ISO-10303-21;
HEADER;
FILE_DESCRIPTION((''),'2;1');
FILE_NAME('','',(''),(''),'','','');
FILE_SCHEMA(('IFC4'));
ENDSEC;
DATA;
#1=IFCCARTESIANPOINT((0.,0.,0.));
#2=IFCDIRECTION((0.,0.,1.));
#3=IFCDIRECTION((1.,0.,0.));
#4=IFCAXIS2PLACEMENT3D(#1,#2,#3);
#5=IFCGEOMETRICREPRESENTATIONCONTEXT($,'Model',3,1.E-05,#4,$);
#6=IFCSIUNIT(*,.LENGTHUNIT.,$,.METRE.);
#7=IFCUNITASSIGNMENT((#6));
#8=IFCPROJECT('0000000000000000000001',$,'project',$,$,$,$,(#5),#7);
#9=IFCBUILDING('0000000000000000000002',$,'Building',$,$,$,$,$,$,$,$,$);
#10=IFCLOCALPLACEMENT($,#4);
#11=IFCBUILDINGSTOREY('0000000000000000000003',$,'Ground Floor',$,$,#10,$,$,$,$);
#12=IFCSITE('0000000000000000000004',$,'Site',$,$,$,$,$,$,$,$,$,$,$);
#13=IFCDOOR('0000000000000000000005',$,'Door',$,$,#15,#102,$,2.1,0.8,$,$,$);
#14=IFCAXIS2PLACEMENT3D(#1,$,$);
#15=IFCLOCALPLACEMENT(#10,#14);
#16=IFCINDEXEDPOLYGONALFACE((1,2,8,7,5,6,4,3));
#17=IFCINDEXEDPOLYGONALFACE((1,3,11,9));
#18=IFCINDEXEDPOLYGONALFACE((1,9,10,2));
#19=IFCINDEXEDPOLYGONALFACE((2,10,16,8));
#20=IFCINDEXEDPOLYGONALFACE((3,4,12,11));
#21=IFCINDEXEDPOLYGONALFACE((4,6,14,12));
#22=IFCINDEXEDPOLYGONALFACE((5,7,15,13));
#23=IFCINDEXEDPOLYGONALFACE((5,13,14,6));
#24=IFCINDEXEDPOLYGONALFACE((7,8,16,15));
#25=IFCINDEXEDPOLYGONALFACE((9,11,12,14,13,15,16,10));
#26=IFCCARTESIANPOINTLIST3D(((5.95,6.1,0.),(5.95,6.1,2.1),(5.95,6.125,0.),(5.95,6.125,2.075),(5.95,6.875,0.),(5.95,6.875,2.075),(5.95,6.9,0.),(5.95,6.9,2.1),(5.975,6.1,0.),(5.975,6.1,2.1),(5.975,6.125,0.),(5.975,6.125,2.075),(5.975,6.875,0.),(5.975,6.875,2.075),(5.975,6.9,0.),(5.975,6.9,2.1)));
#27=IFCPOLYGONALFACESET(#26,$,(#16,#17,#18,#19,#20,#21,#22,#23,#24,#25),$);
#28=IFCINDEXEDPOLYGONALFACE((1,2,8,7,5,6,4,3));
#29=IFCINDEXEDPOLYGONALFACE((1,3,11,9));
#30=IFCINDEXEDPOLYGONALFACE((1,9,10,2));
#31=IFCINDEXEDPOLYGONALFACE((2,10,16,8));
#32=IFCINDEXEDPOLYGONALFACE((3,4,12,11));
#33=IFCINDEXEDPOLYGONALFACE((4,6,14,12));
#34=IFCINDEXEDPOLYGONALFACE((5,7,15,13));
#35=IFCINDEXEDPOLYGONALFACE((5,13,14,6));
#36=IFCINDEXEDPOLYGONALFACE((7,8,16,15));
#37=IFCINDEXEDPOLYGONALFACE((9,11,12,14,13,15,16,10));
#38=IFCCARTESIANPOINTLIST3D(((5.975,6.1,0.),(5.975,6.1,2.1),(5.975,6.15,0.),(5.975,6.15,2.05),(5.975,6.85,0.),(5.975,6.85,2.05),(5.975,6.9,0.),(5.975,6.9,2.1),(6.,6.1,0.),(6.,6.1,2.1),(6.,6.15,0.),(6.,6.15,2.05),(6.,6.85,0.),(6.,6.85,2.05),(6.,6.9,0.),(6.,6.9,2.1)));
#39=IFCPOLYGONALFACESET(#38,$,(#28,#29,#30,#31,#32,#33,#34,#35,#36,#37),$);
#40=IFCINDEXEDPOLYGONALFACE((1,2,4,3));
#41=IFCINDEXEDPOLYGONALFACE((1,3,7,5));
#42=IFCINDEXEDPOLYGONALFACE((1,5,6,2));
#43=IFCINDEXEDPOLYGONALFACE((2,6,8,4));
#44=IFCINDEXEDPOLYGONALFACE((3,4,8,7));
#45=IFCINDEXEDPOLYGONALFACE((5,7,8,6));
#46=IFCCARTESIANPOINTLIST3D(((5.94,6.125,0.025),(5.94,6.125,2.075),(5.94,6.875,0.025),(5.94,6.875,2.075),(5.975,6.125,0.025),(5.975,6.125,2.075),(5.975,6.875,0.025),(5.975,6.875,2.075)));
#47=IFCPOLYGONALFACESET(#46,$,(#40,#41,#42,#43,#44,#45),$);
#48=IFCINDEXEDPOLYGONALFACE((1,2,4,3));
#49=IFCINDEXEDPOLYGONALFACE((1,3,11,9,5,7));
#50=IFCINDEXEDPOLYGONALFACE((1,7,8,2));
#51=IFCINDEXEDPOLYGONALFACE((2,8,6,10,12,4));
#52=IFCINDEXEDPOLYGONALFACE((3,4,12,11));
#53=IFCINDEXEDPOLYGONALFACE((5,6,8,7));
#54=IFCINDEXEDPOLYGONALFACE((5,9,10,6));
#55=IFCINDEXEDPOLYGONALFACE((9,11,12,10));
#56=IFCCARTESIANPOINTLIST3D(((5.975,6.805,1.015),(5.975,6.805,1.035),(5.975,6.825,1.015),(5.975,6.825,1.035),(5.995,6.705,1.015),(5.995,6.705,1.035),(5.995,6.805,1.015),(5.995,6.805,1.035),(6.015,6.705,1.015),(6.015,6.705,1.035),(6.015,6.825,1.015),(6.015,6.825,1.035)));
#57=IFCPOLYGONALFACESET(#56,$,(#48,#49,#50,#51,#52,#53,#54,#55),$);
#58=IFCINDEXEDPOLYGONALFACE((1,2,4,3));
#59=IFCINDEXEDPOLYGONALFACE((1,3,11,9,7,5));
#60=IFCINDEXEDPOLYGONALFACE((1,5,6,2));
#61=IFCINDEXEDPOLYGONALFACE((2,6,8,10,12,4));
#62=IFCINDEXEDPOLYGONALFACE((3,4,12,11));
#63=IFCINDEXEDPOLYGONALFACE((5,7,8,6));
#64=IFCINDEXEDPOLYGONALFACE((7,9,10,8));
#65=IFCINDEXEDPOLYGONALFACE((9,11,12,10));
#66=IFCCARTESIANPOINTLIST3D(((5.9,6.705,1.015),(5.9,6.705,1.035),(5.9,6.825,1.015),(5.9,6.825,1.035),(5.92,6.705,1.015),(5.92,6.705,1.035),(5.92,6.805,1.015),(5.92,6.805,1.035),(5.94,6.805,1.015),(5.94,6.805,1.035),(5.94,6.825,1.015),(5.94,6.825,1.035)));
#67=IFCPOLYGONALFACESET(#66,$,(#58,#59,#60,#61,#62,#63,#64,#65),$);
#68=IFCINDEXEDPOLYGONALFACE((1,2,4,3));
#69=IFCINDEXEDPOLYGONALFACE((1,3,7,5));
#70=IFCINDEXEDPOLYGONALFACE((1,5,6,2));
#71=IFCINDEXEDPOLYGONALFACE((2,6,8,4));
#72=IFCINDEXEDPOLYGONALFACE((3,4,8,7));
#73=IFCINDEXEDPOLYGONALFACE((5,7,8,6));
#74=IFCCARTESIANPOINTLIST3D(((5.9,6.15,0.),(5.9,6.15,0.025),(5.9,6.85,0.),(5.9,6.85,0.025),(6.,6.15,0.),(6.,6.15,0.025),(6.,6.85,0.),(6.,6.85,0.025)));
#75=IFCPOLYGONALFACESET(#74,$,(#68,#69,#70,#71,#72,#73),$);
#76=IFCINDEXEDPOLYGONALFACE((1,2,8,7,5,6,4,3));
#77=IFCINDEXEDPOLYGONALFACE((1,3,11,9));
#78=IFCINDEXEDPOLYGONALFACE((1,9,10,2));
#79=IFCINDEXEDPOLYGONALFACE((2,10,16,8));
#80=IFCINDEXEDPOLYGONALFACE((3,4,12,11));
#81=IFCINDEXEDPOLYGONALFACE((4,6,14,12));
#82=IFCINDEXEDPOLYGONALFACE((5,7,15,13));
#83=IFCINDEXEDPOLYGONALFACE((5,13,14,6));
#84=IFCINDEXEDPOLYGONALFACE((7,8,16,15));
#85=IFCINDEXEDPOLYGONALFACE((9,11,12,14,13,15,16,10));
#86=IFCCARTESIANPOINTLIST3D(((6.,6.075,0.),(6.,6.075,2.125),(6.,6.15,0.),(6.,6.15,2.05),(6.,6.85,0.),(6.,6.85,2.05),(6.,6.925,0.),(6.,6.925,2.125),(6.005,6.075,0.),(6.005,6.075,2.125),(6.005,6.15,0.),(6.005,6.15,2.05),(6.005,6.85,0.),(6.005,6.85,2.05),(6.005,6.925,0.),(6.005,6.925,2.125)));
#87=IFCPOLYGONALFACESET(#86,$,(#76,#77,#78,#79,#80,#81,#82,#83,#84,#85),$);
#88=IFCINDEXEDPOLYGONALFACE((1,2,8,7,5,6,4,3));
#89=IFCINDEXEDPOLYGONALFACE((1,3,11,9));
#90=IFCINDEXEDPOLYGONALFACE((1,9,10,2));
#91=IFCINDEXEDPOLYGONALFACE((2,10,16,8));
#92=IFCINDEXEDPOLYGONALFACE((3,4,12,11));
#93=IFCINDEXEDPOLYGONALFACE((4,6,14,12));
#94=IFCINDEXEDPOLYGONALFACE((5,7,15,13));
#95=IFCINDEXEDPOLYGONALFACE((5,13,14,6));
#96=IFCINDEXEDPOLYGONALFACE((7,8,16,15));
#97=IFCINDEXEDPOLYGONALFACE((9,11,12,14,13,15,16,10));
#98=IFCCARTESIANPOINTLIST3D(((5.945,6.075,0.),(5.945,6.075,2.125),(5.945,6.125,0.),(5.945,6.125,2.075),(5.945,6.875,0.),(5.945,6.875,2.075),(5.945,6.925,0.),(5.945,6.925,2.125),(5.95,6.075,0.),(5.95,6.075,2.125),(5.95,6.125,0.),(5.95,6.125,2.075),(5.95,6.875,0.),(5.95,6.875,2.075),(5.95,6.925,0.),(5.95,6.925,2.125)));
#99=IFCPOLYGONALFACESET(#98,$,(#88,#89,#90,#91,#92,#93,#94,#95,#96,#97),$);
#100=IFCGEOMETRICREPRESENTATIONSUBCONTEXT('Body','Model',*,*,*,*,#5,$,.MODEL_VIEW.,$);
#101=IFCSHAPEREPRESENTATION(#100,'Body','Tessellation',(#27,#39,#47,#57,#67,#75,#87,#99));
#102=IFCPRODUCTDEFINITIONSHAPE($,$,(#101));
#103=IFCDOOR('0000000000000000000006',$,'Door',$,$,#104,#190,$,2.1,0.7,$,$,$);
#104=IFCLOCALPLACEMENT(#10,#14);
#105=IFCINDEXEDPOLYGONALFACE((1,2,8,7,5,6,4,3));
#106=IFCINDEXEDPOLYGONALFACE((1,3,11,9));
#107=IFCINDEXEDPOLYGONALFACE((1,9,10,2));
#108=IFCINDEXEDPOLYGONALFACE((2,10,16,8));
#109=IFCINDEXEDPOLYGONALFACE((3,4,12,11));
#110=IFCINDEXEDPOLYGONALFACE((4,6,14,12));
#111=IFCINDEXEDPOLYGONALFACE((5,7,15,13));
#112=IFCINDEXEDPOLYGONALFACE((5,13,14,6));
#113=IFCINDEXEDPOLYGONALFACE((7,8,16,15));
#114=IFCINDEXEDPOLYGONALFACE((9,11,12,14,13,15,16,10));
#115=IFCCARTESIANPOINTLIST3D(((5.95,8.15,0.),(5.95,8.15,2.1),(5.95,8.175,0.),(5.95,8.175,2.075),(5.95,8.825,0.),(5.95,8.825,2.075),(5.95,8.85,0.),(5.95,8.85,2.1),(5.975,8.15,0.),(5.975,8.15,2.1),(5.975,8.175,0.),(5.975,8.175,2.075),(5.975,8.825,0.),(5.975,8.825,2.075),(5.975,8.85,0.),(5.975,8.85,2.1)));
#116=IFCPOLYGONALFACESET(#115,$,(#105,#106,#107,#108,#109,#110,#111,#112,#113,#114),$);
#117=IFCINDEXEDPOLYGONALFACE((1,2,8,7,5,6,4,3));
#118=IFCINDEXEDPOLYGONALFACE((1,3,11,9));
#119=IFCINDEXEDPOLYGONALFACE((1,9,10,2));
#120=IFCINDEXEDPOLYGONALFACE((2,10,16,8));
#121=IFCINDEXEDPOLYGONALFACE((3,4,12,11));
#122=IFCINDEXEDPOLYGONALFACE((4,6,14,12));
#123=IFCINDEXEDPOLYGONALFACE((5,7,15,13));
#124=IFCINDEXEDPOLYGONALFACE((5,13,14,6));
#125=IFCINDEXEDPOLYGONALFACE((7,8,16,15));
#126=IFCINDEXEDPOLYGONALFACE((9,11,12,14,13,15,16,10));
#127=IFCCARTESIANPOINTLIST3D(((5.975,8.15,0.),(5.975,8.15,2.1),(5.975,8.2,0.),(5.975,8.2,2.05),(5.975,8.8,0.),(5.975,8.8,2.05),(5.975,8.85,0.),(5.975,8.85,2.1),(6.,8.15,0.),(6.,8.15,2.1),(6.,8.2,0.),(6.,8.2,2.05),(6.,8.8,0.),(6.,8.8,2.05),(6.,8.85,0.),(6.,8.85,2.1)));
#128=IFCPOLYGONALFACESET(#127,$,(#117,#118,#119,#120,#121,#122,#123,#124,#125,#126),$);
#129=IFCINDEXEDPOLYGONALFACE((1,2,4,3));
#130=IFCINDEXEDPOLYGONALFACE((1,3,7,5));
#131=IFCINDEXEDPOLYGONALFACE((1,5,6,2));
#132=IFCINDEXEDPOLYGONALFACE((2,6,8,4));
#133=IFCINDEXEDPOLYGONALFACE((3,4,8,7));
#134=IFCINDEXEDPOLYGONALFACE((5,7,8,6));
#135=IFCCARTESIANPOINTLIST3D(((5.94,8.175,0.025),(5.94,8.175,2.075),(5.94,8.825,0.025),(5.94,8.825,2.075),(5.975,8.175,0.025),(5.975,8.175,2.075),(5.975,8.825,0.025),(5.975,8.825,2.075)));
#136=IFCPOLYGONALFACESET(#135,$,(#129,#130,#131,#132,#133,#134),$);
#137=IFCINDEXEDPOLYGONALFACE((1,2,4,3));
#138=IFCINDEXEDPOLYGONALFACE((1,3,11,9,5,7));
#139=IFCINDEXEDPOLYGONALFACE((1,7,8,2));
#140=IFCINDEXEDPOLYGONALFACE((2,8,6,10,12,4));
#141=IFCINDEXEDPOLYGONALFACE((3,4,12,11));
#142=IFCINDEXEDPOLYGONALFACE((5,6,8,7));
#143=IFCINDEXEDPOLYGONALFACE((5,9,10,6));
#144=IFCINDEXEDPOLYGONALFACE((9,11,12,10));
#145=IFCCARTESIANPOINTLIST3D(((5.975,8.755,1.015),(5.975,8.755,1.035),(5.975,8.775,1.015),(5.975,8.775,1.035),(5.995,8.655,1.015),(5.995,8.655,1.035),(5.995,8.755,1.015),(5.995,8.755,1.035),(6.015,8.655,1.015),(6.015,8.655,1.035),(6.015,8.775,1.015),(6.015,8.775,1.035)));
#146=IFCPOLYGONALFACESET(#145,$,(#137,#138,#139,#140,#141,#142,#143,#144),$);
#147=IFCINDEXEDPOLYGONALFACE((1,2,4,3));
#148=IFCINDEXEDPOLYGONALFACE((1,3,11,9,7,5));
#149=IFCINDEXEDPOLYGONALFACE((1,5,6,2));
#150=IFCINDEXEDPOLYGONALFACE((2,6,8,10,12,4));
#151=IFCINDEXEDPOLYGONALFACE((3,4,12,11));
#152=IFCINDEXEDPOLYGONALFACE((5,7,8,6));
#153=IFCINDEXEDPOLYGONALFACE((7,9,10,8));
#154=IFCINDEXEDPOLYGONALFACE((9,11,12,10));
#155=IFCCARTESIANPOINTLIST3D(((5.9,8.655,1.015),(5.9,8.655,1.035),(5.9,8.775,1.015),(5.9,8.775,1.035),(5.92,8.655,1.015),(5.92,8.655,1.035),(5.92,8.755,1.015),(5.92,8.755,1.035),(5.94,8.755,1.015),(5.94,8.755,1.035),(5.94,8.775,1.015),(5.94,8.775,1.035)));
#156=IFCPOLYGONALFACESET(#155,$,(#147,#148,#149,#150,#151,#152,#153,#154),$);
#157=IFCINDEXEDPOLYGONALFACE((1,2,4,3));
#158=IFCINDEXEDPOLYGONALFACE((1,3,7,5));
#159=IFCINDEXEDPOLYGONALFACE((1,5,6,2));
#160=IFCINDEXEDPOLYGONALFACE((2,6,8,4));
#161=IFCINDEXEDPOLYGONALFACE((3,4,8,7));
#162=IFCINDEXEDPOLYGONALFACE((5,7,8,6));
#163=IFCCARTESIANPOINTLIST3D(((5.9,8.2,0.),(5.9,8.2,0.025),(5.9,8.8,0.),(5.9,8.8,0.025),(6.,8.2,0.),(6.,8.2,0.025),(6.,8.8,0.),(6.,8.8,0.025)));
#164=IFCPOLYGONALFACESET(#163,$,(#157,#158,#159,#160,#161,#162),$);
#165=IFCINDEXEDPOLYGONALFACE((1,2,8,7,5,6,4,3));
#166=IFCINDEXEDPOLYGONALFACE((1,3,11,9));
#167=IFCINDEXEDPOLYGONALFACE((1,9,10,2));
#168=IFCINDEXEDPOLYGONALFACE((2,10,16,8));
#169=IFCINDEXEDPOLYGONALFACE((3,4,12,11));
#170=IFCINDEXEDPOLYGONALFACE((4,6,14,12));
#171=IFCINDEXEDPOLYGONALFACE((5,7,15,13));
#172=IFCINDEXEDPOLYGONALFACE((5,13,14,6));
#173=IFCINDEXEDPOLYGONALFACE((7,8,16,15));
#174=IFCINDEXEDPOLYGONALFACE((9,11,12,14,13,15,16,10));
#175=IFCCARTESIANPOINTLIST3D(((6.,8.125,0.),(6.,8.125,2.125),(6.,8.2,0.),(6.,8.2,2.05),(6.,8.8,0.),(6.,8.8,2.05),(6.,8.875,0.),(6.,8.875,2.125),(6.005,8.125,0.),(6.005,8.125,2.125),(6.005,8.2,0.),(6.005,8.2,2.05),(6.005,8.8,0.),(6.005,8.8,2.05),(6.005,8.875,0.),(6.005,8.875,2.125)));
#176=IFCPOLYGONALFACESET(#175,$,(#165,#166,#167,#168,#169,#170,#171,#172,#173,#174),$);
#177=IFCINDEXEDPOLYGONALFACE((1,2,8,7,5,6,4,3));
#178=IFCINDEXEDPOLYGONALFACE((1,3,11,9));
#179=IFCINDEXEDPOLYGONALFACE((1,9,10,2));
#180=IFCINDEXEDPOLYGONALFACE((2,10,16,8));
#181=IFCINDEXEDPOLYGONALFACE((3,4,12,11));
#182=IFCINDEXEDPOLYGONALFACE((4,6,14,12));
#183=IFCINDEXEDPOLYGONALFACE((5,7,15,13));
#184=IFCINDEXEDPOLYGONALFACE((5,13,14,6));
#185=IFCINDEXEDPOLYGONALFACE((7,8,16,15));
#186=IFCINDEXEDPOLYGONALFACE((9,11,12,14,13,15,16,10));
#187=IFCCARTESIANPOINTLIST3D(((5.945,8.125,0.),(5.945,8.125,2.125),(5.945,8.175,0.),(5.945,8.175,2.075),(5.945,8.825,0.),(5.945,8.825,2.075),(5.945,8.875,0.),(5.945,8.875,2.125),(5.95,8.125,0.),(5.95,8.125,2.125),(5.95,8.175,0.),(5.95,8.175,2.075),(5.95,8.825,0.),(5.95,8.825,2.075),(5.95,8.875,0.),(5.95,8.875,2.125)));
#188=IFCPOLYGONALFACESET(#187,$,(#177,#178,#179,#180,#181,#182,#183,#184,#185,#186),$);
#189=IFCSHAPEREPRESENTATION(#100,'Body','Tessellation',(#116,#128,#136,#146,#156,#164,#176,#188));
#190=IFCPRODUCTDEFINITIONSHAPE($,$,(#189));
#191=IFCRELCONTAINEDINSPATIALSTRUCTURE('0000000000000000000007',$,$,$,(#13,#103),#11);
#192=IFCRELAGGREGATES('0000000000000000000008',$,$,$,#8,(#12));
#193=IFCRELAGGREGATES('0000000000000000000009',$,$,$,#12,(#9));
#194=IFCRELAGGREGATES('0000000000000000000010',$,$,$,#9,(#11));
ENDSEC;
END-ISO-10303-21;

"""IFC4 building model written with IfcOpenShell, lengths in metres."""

from ifc_helpers import new_model, si_unit, frame, origin_with_axes, place, context, subcontext, project, spatial, line, indexed_curve, outline, extrude, element, save


model = new_model("IFC4")

# Units and contexts
model_context = context("Model", 3, precision=1e-05, world=origin_with_axes())
body_context = subcontext(model_context, "Body", "Model", "MODEL_VIEW")
ifc_project = project(units=[si_unit("LENGTHUNIT", "METRE")], contexts=[model_context])

# Site, building, storey
site = spatial("IfcSite", under=ifc_project, Name="Site")
building = spatial("IfcBuilding", under=site, Name="Building")
storey_placement = place(None, origin_with_axes())
storey = spatial("IfcBuildingStorey", under=building, at=storey_placement, Name="Ground Floor")

# Doors
door_1_placement = place(storey_placement, frame((6.0, 6.1, 0.0), z_axis=(0.0, 0.0, 1.0), x_axis=(0.0, 1.0, 0.0)))
element("IfcDoor", 1, at=door_1_placement, inside=storey, Name="Door", OverallHeight=2.1, OverallWidth=0.8, context=body_context, shape_type="SweptSolid", body=[
    extrude(outline(indexed_curve([(0.0, 0.0), (0.0, 2.1), (0.8, 2.1), (0.8, 0.0), (0.775, 0.0), (0.775, 2.075), (0.025, 2.075), (0.025, 0.0)], segments=[line(1, 2, 3, 4, 5, 6, 7, 8, 1)])), frame((0.0, 0.025, 0.0), z_axis=(0.0, -1.0, 0.0), x_axis=(1.0, 0.0, 0.0)), (0.0, 0.0, -1.0), 0.025),
    extrude(outline(indexed_curve([(0.0, 0.0), (0.0, 2.1), (0.8, 2.1), (0.8, 0.0), (0.75, 0.0), (0.75, 2.05), (0.05, 2.05), (0.05, 0.0)], segments=[line(1, 2, 3, 4, 5, 6, 7, 8, 1)])), frame((0.0, 0.0, 0.0), z_axis=(0.0, -1.0, 0.0), x_axis=(1.0, 0.0, 0.0)), (0.0, 0.0, -1.0), 0.025),
    extrude(outline(indexed_curve([(0.0, 0.0), (0.75, 0.0), (0.75, 0.035), (0.0, 0.035)], segments=[line(1, 2, 3, 4, 1)])), frame((0.025, 0.025, 0.025), z_axis=(0.0, 0.0, 1.0), x_axis=(1.0, 0.0, 0.0)), (0.0, 0.0, 1.0), 2.05),
    extrude(outline(indexed_curve([(0.0, 0.0), (0.0, -0.04), (-0.12, -0.04), (-0.12, -0.02), (-0.02, -0.02), (-0.02, 0.0)], segments=[line(1, 2, 3, 4, 5, 6, 1)])), frame((0.725, 0.025, 1.015), z_axis=(0.0, 0.0, 1.0), x_axis=(1.0, 0.0, 0.0)), (0.0, 0.0, 1.0), 0.02),
    extrude(outline(indexed_curve([(0.0, 0.0), (0.0, 0.04), (-0.12, 0.04), (-0.12, 0.02), (-0.02, 0.02), (-0.02, 0.0)], segments=[line(1, 2, 3, 4, 5, 6, 1)])), frame((0.725, 0.06, 1.015), z_axis=(0.0, 0.0, 1.0), x_axis=(1.0, 0.0, 0.0)), (0.0, 0.0, 1.0), 0.02),
    extrude(outline(indexed_curve([(0.0, 0.0), (0.7, 0.0), (0.7, 0.1), (0.0, 0.1)], segments=[line(1, 2, 3, 4, 1)])), frame((0.05, 0.0, 0.0), z_axis=(0.0, 0.0, 1.0), x_axis=(1.0, 0.0, 0.0)), (0.0, 0.0, 1.0), 0.025),
    extrude(outline(indexed_curve([(0.0, 0.0), (0.0, 2.125), (0.85, 2.125), (0.85, 0.0), (0.775, 0.0), (0.775, 2.05), (0.075, 2.05), (0.075, 0.0)], segments=[line(1, 2, 3, 4, 5, 6, 7, 8, 1)])), frame((-0.025, -0.005, 0.0), z_axis=(0.0, -1.0, 0.0), x_axis=(1.0, 0.0, 0.0)), (0.0, 0.0, -1.0), 0.005),
    extrude(outline(indexed_curve([(0.0, 0.0), (0.0, 2.125), (0.85, 2.125), (0.85, 0.0), (0.8, 0.0), (0.8, 2.075), (0.05, 2.075), (0.05, 0.0)], segments=[line(1, 2, 3, 4, 5, 6, 7, 8, 1)])), frame((-0.025, 0.05, 0.0), z_axis=(0.0, -1.0, 0.0), x_axis=(1.0, 0.0, 0.0)), (0.0, 0.0, -1.0), 0.005),
])
door_2_placement = place(storey_placement, frame((6.0, 8.15, 0.0), z_axis=(0.0, 0.0, 1.0), x_axis=(0.0, 1.0, 0.0)))
element("IfcDoor", 2, at=door_2_placement, inside=storey, Name="Door", OverallHeight=2.1, OverallWidth=0.7, context=body_context, shape_type="SweptSolid", body=[
    extrude(outline(indexed_curve([(0.0, 0.0), (0.0, 2.1), (0.7, 2.1), (0.7, 0.0), (0.675, 0.0), (0.675, 2.075), (0.025, 2.075), (0.025, 0.0)], segments=[line(1, 2, 3, 4, 5, 6, 7, 8, 1)])), frame((0.0, 0.025, 0.0), z_axis=(0.0, -1.0, 0.0), x_axis=(1.0, 0.0, 0.0)), (0.0, 0.0, -1.0), 0.025),
    extrude(outline(indexed_curve([(0.0, 0.0), (0.0, 2.1), (0.7, 2.1), (0.7, 0.0), (0.65, 0.0), (0.65, 2.05), (0.05, 2.05), (0.05, 0.0)], segments=[line(1, 2, 3, 4, 5, 6, 7, 8, 1)])), frame((0.0, 0.0, 0.0), z_axis=(0.0, -1.0, 0.0), x_axis=(1.0, 0.0, 0.0)), (0.0, 0.0, -1.0), 0.025),
    extrude(outline(indexed_curve([(0.0, 0.0), (0.65, 0.0), (0.65, 0.035), (0.0, 0.035)], segments=[line(1, 2, 3, 4, 1)])), frame((0.025, 0.025, 0.025), z_axis=(0.0, 0.0, 1.0), x_axis=(1.0, 0.0, 0.0)), (0.0, 0.0, 1.0), 2.05),
    extrude(outline(indexed_curve([(0.0, 0.0), (0.0, -0.04), (-0.12, -0.04), (-0.12, -0.02), (-0.02, -0.02), (-0.02, 0.0)], segments=[line(1, 2, 3, 4, 5, 6, 1)])), frame((0.625, 0.025, 1.015), z_axis=(0.0, 0.0, 1.0), x_axis=(1.0, 0.0, 0.0)), (0.0, 0.0, 1.0), 0.02),
    extrude(outline(indexed_curve([(0.0, 0.0), (0.0, 0.04), (-0.12, 0.04), (-0.12, 0.02), (-0.02, 0.02), (-0.02, 0.0)], segments=[line(1, 2, 3, 4, 5, 6, 1)])), frame((0.625, 0.06, 1.015), z_axis=(0.0, 0.0, 1.0), x_axis=(1.0, 0.0, 0.0)), (0.0, 0.0, 1.0), 0.02),
    extrude(outline(indexed_curve([(0.0, 0.0), (0.6, 0.0), (0.6, 0.1), (0.0, 0.1)], segments=[line(1, 2, 3, 4, 1)])), frame((0.05, 0.0, 0.0), z_axis=(0.0, 0.0, 1.0), x_axis=(1.0, 0.0, 0.0)), (0.0, 0.0, 1.0), 0.025),
    extrude(outline(indexed_curve([(0.0, 0.0), (0.0, 2.125), (0.75, 2.125), (0.75, 0.0), (0.675, 0.0), (0.675, 2.05), (0.075, 2.05), (0.075, 0.0)], segments=[line(1, 2, 3, 4, 5, 6, 7, 8, 1)])), frame((-0.025, -0.005, 0.0), z_axis=(0.0, -1.0, 0.0), x_axis=(1.0, 0.0, 0.0)), (0.0, 0.0, -1.0), 0.005),
    extrude(outline(indexed_curve([(0.0, 0.0), (0.0, 2.125), (0.75, 2.125), (0.75, 0.0), (0.7, 0.0), (0.7, 2.075), (0.05, 2.075), (0.05, 0.0)], segments=[line(1, 2, 3, 4, 5, 6, 7, 8, 1)])), frame((-0.025, 0.05, 0.0), z_axis=(0.0, -1.0, 0.0), x_axis=(1.0, 0.0, 0.0)), (0.0, 0.0, -1.0), 0.005),
])

save(model, "model.ifc")
